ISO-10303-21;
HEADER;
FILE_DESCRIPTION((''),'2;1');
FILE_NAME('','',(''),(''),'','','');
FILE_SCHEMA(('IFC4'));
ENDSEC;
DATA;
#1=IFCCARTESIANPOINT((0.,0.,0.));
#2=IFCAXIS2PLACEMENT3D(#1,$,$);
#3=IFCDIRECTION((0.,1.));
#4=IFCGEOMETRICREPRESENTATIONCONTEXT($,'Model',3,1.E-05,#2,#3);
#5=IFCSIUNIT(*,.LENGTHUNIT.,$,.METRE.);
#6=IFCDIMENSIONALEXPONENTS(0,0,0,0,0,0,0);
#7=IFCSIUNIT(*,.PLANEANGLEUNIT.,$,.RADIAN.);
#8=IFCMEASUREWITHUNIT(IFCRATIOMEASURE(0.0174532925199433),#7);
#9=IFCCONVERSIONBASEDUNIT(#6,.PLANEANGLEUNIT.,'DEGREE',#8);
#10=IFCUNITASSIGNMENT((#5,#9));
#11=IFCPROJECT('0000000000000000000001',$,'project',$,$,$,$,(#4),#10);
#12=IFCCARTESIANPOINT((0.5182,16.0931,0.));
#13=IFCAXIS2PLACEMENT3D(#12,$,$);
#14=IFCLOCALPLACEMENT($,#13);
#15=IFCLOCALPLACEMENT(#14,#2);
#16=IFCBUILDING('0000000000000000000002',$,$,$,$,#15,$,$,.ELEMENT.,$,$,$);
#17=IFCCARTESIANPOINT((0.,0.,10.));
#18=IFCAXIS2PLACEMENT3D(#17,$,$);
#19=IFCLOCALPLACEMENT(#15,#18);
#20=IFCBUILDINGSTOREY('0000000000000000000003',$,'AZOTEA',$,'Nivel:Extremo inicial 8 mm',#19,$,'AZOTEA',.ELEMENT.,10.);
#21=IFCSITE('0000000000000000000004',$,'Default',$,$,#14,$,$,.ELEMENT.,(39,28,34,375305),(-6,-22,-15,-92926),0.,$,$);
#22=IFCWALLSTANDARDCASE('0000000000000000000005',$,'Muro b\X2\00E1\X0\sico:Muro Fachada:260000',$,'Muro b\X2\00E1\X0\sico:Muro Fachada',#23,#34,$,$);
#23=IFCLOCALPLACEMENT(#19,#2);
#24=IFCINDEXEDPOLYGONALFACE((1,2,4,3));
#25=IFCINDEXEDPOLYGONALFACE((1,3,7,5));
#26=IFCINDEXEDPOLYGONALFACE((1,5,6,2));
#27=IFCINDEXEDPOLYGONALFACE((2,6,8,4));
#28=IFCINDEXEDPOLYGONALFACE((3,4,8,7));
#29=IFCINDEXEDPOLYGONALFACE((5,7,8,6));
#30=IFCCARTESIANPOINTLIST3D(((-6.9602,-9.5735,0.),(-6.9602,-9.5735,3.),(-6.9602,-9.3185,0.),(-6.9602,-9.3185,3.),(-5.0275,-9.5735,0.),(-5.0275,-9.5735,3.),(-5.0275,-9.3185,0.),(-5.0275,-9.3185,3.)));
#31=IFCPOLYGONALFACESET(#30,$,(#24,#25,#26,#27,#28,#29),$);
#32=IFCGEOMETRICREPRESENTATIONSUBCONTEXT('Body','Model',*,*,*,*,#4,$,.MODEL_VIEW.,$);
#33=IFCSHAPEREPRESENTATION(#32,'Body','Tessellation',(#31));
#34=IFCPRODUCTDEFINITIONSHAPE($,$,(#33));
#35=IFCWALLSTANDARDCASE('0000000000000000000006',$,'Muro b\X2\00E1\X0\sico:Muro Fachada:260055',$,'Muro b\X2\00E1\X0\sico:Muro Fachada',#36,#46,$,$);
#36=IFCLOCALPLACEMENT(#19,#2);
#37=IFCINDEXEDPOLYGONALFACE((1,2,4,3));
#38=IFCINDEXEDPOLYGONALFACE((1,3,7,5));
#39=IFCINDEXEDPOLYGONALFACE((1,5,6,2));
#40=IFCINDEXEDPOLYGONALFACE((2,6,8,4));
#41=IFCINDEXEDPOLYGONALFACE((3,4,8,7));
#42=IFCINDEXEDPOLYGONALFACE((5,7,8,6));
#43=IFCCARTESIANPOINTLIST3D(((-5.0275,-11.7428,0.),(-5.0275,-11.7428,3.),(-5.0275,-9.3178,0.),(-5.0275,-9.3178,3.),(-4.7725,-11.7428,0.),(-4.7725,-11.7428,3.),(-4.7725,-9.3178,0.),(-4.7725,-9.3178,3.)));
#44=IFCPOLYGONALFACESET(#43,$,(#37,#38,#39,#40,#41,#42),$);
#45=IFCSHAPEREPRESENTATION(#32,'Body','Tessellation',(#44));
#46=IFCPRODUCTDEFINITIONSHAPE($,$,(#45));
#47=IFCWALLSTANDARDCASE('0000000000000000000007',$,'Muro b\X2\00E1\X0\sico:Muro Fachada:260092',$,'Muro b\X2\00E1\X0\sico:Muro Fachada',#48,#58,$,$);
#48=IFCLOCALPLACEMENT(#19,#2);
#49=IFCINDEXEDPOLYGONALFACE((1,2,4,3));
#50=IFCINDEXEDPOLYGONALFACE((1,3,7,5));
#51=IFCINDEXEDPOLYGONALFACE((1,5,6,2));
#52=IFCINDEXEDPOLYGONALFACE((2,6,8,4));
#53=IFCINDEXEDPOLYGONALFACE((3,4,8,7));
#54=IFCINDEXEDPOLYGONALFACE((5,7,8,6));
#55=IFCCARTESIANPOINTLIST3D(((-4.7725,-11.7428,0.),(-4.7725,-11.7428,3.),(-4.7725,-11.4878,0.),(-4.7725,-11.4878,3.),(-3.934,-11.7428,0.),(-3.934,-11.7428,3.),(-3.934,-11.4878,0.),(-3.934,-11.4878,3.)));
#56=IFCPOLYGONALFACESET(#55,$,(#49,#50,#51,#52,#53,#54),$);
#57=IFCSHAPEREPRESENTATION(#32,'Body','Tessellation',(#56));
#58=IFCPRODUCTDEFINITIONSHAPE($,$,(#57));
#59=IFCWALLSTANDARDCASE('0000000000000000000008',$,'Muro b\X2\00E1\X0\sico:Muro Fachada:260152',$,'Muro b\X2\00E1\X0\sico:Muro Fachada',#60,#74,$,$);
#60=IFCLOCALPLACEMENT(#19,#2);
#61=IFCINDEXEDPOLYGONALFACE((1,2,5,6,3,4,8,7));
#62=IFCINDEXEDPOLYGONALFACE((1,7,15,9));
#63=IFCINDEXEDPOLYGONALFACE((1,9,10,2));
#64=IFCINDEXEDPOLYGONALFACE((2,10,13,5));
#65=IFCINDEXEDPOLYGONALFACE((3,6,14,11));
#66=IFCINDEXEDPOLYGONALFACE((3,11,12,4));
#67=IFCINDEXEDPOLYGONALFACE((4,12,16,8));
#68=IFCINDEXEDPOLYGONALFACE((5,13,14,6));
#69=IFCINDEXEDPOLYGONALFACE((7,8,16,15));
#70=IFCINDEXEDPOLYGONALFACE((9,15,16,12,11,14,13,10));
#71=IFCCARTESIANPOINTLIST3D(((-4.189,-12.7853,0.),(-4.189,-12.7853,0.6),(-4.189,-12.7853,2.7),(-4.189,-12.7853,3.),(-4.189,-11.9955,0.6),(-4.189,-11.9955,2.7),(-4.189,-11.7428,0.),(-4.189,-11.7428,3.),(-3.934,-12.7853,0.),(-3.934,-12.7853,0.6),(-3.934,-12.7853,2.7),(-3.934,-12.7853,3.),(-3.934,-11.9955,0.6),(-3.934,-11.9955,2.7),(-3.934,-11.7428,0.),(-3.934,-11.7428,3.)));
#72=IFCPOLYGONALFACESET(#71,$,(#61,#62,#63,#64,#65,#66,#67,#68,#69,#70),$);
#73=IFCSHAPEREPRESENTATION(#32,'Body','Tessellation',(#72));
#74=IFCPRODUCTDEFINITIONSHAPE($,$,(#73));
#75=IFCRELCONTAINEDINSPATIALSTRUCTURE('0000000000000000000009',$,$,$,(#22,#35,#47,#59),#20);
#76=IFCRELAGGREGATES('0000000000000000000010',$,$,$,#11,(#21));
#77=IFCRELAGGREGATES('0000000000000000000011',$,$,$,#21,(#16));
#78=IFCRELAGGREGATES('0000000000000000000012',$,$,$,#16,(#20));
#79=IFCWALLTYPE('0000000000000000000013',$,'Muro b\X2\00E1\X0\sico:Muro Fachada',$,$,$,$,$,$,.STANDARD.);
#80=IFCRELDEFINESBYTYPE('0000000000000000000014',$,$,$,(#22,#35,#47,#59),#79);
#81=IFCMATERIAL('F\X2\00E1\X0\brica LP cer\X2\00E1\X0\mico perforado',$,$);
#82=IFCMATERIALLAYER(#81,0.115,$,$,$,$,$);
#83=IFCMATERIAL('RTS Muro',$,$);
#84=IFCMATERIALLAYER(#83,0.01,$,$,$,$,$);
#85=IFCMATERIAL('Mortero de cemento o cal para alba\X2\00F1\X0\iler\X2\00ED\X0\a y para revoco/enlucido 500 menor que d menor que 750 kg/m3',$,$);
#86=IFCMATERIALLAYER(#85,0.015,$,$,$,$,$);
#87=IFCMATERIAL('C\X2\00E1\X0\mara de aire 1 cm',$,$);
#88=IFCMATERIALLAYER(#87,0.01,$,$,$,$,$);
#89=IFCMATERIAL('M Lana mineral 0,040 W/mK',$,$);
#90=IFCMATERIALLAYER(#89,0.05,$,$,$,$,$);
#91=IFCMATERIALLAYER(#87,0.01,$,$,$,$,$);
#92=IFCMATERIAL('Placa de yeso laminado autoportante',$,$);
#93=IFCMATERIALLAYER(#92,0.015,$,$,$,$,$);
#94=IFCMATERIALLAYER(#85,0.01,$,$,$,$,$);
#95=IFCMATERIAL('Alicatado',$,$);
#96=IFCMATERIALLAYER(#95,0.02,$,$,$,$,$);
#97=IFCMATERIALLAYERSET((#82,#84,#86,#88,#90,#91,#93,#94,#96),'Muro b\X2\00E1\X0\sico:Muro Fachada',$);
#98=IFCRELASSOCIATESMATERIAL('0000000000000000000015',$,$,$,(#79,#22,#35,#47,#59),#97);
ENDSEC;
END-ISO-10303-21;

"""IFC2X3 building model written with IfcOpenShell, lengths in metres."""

from ifc_helpers import new_model, entity, si_unit, converted_unit, direction, frame, frame_2d, origin, place, context, subcontext, project, spatial, polyline, rectangle, extrude, clip, bounded_halfspace, material, layer, layer_set, layer_usage, type_object, element, save


model = new_model("IFC2X3")

# Units and contexts
model_context = context("Model", 3, precision=1e-05, world=origin(), true_north=direction((0.0, 1.0)))
body_context = subcontext(model_context, "Body", "Model", "MODEL_VIEW")
ifc_project = project(units=[si_unit("LENGTHUNIT", "METRE"), converted_unit("PLANEANGLEUNIT", "DEGREE", entity("IfcRatioMeasure", 0.0174532925199433), si_unit("PLANEANGLEUNIT", "RADIAN"), dimensions=[0, 0, 0, 0, 0, 0, 0])], contexts=[model_context])

# Site, building, storey
site_placement = place(None, frame((0.5182, 16.0931, 0.0)))
site = spatial("IfcSite", under=ifc_project, at=site_placement, Name="Default", CompositionType="ELEMENT", RefLatitude=(39, 28, 34, 375305), RefLongitude=(-6, -22, -15, -92926), RefElevation=0.0)
building_placement = place(site_placement, origin())
building = spatial("IfcBuilding", under=site, at=building_placement, CompositionType="ELEMENT")
storey_placement = place(building_placement, frame((0.0, 0.0, 10.0)))
storey = spatial("IfcBuildingStorey", under=building, at=storey_placement, Name="AZOTEA", ObjectType="Nivel:Extremo inicial 8 mm", LongName="AZOTEA", CompositionType="ELEMENT", Elevation=10.0)

# Walls
ifc_material_1 = material(Name="Fábrica LP cerámico perforado")
ifc_layer_1 = layer(ifc_material_1, 0.115)
ifc_material_2 = material(Name="RTS Muro")
ifc_layer_2 = layer(ifc_material_2, 0.01)
ifc_material_3 = material(Name="Mortero de cemento o cal para albañilería y para revoco/enlucido 500 menor que d menor que 750 kg/m3")
ifc_layer_3 = layer(ifc_material_3, 0.015)
ifc_material_4 = material(Name="Cámara de aire 1 cm")
ifc_layer_4 = layer(ifc_material_4, 0.01)
ifc_material_5 = material(Name="M Lana mineral 0,040 W/mK")
ifc_layer_5 = layer(ifc_material_5, 0.05)
ifc_layer_6 = layer(ifc_material_4, 0.01)
ifc_material_6 = material(Name="Placa de yeso laminado autoportante")
ifc_layer_7 = layer(ifc_material_6, 0.015)
ifc_layer_8 = layer(ifc_material_3, 0.01)
ifc_material_7 = material(Name="Alicatado")
ifc_layer_9 = layer(ifc_material_7, 0.02)
ifc_layer_set = layer_set([ifc_layer_1, ifc_layer_2, ifc_layer_3, ifc_layer_4, ifc_layer_5, ifc_layer_6, ifc_layer_7, ifc_layer_8, ifc_layer_9], Name="Muro básico:Muro Fachada")
ifc_layer_usage_1 = layer_usage(ifc_layer_set, "AXIS2", "NEGATIVE", 0.1275)
wall_type = type_object("IfcWallType", Name="Muro básico:Muro Fachada", PredefinedType="STANDARD", material=ifc_layer_set)
wall_1_placement = place(storey_placement, frame((-6.9602, -9.446, 0.0)))
element("IfcWallStandardCase", 1, at=wall_1_placement, inside=storey, type_object=wall_type, material=ifc_layer_usage_1, Name="Muro básico:Muro Fachada:260000", ObjectType="Muro básico:Muro Fachada", context=body_context, shape_type="Clipping", body=[
    clip(extrude(rectangle(XDim=1.9328, YDim=0.255, at=frame_2d((0.9664, 0.0), x_axis=(-1.0, 0.0))), origin(), (0.0, 0.0, 1.0), 3.0), bounded_halfspace(frame((0.0, -0.1275, 3.0)), False, frame((0.0, -0.1275, 3.0)), polyline([(0.0, 0.0), (1.9328, 0.0), (1.9328, 0.255), (0.0, 0.255), (0.0, 0.0)]))),
])
ifc_layer_usage_2 = layer_usage(ifc_layer_set, "AXIS2", "NEGATIVE", 0.1275)
wall_2_placement = place(storey_placement, frame((-4.9, -9.3178, 0.0), z_axis=(0.0, 0.0, 1.0), x_axis=(0.0, -1.0, 0.0)))
element("IfcWallStandardCase", 2, at=wall_2_placement, inside=storey, type_object=wall_type, material=ifc_layer_usage_2, Name="Muro básico:Muro Fachada:260055", ObjectType="Muro básico:Muro Fachada", context=body_context, shape_type="Clipping", body=[
    clip(extrude(rectangle(XDim=2.425, YDim=0.255, at=frame_2d((1.2125, 0.0), x_axis=(-1.0, 0.0))), origin(), (0.0, 0.0, 1.0), 3.0), bounded_halfspace(frame((0.0, -0.1275, 3.0), z_axis=(0.0, 0.0, 1.0), x_axis=(0.0, 1.0, 0.0)), False, frame((0.0, -0.1275, 3.0)), polyline([(0.0, 0.0), (0.0007, 0.0), (0.2557, 0.0), (2.425, 0.0), (2.425, 0.255), (2.17, 0.255), (0.0, 0.255), (0.0, 0.0)]))),
])
ifc_layer_usage_3 = layer_usage(ifc_layer_set, "AXIS2", "NEGATIVE", 0.1275)
wall_3_placement = place(storey_placement, frame((-4.7725, -11.6153, 0.0)))
element("IfcWallStandardCase", 3, at=wall_3_placement, inside=storey, type_object=wall_type, material=ifc_layer_usage_3, Name="Muro básico:Muro Fachada:260092", ObjectType="Muro básico:Muro Fachada", context=body_context, shape_type="Clipping", body=[
    clip(extrude(rectangle(XDim=0.8385, YDim=0.255, at=frame_2d((0.4192, 0.0), x_axis=(-1.0, 0.0))), origin(), (0.0, 0.0, 1.0), 3.0), bounded_halfspace(frame((0.0, -0.1275, 3.0)), False, frame((0.0, -0.1275, 3.0)), polyline([(0.0, 0.0), (0.5835, 0.0), (0.8266, 0.0), (0.8266, 0.255), (0.0, 0.255), (0.0, 0.0)]))),
])

# Wall, opening
ifc_layer_usage_4 = layer_usage(ifc_layer_set, "AXIS2", "NEGATIVE", 0.1275)
wall_4_placement = place(storey_placement, frame((-4.0615, -11.7428, 0.0), z_axis=(0.0, 0.0, 1.0), x_axis=(0.0, -1.0, 0.0)))
wall_4 = element("IfcWallStandardCase", 4, at=wall_4_placement, inside=storey, type_object=wall_type, material=ifc_layer_usage_4, Name="Muro básico:Muro Fachada:260152", ObjectType="Muro básico:Muro Fachada", context=body_context, shape_type="Clipping", body=[
    clip(extrude(rectangle(XDim=1.0425, YDim=0.255, at=frame_2d((0.5213, 0.0), x_axis=(-1.0, 0.0))), origin(), (0.0, 0.0, 1.0), 3.0), bounded_halfspace(frame((0.0, -0.1275, 3.0), z_axis=(0.0, 0.0, 1.0), x_axis=(0.0, 1.0, 0.0)), False, frame((0.0, -0.1275, 3.0)), polyline([(0.0, 0.0), (1.0425, 0.0), (1.0425, 0.2431), (0.0, 0.2431), (0.0, 0.0)]))),
])
opening_1_placement = place(wall_4_placement, frame((0.2527, -0.1275, 0.6)))
element("IfcOpeningElement", 5, at=opening_1_placement, cuts=wall_4, ObjectType="Opening", context=body_context, shape_type="SweptSolid", body=[
    extrude(rectangle(XDim=2.1, YDim=0.8, at=frame_2d((1.05, 0.4), x_axis=(1.0, 0.0))), frame((0.0, 0.0, 0.0), z_axis=(0.0, 1.0, 0.0), x_axis=(0.0, 0.0, 1.0)), (0.0, 0.0, 1.0), 0.255),
])

save(model, "model.ifc")
